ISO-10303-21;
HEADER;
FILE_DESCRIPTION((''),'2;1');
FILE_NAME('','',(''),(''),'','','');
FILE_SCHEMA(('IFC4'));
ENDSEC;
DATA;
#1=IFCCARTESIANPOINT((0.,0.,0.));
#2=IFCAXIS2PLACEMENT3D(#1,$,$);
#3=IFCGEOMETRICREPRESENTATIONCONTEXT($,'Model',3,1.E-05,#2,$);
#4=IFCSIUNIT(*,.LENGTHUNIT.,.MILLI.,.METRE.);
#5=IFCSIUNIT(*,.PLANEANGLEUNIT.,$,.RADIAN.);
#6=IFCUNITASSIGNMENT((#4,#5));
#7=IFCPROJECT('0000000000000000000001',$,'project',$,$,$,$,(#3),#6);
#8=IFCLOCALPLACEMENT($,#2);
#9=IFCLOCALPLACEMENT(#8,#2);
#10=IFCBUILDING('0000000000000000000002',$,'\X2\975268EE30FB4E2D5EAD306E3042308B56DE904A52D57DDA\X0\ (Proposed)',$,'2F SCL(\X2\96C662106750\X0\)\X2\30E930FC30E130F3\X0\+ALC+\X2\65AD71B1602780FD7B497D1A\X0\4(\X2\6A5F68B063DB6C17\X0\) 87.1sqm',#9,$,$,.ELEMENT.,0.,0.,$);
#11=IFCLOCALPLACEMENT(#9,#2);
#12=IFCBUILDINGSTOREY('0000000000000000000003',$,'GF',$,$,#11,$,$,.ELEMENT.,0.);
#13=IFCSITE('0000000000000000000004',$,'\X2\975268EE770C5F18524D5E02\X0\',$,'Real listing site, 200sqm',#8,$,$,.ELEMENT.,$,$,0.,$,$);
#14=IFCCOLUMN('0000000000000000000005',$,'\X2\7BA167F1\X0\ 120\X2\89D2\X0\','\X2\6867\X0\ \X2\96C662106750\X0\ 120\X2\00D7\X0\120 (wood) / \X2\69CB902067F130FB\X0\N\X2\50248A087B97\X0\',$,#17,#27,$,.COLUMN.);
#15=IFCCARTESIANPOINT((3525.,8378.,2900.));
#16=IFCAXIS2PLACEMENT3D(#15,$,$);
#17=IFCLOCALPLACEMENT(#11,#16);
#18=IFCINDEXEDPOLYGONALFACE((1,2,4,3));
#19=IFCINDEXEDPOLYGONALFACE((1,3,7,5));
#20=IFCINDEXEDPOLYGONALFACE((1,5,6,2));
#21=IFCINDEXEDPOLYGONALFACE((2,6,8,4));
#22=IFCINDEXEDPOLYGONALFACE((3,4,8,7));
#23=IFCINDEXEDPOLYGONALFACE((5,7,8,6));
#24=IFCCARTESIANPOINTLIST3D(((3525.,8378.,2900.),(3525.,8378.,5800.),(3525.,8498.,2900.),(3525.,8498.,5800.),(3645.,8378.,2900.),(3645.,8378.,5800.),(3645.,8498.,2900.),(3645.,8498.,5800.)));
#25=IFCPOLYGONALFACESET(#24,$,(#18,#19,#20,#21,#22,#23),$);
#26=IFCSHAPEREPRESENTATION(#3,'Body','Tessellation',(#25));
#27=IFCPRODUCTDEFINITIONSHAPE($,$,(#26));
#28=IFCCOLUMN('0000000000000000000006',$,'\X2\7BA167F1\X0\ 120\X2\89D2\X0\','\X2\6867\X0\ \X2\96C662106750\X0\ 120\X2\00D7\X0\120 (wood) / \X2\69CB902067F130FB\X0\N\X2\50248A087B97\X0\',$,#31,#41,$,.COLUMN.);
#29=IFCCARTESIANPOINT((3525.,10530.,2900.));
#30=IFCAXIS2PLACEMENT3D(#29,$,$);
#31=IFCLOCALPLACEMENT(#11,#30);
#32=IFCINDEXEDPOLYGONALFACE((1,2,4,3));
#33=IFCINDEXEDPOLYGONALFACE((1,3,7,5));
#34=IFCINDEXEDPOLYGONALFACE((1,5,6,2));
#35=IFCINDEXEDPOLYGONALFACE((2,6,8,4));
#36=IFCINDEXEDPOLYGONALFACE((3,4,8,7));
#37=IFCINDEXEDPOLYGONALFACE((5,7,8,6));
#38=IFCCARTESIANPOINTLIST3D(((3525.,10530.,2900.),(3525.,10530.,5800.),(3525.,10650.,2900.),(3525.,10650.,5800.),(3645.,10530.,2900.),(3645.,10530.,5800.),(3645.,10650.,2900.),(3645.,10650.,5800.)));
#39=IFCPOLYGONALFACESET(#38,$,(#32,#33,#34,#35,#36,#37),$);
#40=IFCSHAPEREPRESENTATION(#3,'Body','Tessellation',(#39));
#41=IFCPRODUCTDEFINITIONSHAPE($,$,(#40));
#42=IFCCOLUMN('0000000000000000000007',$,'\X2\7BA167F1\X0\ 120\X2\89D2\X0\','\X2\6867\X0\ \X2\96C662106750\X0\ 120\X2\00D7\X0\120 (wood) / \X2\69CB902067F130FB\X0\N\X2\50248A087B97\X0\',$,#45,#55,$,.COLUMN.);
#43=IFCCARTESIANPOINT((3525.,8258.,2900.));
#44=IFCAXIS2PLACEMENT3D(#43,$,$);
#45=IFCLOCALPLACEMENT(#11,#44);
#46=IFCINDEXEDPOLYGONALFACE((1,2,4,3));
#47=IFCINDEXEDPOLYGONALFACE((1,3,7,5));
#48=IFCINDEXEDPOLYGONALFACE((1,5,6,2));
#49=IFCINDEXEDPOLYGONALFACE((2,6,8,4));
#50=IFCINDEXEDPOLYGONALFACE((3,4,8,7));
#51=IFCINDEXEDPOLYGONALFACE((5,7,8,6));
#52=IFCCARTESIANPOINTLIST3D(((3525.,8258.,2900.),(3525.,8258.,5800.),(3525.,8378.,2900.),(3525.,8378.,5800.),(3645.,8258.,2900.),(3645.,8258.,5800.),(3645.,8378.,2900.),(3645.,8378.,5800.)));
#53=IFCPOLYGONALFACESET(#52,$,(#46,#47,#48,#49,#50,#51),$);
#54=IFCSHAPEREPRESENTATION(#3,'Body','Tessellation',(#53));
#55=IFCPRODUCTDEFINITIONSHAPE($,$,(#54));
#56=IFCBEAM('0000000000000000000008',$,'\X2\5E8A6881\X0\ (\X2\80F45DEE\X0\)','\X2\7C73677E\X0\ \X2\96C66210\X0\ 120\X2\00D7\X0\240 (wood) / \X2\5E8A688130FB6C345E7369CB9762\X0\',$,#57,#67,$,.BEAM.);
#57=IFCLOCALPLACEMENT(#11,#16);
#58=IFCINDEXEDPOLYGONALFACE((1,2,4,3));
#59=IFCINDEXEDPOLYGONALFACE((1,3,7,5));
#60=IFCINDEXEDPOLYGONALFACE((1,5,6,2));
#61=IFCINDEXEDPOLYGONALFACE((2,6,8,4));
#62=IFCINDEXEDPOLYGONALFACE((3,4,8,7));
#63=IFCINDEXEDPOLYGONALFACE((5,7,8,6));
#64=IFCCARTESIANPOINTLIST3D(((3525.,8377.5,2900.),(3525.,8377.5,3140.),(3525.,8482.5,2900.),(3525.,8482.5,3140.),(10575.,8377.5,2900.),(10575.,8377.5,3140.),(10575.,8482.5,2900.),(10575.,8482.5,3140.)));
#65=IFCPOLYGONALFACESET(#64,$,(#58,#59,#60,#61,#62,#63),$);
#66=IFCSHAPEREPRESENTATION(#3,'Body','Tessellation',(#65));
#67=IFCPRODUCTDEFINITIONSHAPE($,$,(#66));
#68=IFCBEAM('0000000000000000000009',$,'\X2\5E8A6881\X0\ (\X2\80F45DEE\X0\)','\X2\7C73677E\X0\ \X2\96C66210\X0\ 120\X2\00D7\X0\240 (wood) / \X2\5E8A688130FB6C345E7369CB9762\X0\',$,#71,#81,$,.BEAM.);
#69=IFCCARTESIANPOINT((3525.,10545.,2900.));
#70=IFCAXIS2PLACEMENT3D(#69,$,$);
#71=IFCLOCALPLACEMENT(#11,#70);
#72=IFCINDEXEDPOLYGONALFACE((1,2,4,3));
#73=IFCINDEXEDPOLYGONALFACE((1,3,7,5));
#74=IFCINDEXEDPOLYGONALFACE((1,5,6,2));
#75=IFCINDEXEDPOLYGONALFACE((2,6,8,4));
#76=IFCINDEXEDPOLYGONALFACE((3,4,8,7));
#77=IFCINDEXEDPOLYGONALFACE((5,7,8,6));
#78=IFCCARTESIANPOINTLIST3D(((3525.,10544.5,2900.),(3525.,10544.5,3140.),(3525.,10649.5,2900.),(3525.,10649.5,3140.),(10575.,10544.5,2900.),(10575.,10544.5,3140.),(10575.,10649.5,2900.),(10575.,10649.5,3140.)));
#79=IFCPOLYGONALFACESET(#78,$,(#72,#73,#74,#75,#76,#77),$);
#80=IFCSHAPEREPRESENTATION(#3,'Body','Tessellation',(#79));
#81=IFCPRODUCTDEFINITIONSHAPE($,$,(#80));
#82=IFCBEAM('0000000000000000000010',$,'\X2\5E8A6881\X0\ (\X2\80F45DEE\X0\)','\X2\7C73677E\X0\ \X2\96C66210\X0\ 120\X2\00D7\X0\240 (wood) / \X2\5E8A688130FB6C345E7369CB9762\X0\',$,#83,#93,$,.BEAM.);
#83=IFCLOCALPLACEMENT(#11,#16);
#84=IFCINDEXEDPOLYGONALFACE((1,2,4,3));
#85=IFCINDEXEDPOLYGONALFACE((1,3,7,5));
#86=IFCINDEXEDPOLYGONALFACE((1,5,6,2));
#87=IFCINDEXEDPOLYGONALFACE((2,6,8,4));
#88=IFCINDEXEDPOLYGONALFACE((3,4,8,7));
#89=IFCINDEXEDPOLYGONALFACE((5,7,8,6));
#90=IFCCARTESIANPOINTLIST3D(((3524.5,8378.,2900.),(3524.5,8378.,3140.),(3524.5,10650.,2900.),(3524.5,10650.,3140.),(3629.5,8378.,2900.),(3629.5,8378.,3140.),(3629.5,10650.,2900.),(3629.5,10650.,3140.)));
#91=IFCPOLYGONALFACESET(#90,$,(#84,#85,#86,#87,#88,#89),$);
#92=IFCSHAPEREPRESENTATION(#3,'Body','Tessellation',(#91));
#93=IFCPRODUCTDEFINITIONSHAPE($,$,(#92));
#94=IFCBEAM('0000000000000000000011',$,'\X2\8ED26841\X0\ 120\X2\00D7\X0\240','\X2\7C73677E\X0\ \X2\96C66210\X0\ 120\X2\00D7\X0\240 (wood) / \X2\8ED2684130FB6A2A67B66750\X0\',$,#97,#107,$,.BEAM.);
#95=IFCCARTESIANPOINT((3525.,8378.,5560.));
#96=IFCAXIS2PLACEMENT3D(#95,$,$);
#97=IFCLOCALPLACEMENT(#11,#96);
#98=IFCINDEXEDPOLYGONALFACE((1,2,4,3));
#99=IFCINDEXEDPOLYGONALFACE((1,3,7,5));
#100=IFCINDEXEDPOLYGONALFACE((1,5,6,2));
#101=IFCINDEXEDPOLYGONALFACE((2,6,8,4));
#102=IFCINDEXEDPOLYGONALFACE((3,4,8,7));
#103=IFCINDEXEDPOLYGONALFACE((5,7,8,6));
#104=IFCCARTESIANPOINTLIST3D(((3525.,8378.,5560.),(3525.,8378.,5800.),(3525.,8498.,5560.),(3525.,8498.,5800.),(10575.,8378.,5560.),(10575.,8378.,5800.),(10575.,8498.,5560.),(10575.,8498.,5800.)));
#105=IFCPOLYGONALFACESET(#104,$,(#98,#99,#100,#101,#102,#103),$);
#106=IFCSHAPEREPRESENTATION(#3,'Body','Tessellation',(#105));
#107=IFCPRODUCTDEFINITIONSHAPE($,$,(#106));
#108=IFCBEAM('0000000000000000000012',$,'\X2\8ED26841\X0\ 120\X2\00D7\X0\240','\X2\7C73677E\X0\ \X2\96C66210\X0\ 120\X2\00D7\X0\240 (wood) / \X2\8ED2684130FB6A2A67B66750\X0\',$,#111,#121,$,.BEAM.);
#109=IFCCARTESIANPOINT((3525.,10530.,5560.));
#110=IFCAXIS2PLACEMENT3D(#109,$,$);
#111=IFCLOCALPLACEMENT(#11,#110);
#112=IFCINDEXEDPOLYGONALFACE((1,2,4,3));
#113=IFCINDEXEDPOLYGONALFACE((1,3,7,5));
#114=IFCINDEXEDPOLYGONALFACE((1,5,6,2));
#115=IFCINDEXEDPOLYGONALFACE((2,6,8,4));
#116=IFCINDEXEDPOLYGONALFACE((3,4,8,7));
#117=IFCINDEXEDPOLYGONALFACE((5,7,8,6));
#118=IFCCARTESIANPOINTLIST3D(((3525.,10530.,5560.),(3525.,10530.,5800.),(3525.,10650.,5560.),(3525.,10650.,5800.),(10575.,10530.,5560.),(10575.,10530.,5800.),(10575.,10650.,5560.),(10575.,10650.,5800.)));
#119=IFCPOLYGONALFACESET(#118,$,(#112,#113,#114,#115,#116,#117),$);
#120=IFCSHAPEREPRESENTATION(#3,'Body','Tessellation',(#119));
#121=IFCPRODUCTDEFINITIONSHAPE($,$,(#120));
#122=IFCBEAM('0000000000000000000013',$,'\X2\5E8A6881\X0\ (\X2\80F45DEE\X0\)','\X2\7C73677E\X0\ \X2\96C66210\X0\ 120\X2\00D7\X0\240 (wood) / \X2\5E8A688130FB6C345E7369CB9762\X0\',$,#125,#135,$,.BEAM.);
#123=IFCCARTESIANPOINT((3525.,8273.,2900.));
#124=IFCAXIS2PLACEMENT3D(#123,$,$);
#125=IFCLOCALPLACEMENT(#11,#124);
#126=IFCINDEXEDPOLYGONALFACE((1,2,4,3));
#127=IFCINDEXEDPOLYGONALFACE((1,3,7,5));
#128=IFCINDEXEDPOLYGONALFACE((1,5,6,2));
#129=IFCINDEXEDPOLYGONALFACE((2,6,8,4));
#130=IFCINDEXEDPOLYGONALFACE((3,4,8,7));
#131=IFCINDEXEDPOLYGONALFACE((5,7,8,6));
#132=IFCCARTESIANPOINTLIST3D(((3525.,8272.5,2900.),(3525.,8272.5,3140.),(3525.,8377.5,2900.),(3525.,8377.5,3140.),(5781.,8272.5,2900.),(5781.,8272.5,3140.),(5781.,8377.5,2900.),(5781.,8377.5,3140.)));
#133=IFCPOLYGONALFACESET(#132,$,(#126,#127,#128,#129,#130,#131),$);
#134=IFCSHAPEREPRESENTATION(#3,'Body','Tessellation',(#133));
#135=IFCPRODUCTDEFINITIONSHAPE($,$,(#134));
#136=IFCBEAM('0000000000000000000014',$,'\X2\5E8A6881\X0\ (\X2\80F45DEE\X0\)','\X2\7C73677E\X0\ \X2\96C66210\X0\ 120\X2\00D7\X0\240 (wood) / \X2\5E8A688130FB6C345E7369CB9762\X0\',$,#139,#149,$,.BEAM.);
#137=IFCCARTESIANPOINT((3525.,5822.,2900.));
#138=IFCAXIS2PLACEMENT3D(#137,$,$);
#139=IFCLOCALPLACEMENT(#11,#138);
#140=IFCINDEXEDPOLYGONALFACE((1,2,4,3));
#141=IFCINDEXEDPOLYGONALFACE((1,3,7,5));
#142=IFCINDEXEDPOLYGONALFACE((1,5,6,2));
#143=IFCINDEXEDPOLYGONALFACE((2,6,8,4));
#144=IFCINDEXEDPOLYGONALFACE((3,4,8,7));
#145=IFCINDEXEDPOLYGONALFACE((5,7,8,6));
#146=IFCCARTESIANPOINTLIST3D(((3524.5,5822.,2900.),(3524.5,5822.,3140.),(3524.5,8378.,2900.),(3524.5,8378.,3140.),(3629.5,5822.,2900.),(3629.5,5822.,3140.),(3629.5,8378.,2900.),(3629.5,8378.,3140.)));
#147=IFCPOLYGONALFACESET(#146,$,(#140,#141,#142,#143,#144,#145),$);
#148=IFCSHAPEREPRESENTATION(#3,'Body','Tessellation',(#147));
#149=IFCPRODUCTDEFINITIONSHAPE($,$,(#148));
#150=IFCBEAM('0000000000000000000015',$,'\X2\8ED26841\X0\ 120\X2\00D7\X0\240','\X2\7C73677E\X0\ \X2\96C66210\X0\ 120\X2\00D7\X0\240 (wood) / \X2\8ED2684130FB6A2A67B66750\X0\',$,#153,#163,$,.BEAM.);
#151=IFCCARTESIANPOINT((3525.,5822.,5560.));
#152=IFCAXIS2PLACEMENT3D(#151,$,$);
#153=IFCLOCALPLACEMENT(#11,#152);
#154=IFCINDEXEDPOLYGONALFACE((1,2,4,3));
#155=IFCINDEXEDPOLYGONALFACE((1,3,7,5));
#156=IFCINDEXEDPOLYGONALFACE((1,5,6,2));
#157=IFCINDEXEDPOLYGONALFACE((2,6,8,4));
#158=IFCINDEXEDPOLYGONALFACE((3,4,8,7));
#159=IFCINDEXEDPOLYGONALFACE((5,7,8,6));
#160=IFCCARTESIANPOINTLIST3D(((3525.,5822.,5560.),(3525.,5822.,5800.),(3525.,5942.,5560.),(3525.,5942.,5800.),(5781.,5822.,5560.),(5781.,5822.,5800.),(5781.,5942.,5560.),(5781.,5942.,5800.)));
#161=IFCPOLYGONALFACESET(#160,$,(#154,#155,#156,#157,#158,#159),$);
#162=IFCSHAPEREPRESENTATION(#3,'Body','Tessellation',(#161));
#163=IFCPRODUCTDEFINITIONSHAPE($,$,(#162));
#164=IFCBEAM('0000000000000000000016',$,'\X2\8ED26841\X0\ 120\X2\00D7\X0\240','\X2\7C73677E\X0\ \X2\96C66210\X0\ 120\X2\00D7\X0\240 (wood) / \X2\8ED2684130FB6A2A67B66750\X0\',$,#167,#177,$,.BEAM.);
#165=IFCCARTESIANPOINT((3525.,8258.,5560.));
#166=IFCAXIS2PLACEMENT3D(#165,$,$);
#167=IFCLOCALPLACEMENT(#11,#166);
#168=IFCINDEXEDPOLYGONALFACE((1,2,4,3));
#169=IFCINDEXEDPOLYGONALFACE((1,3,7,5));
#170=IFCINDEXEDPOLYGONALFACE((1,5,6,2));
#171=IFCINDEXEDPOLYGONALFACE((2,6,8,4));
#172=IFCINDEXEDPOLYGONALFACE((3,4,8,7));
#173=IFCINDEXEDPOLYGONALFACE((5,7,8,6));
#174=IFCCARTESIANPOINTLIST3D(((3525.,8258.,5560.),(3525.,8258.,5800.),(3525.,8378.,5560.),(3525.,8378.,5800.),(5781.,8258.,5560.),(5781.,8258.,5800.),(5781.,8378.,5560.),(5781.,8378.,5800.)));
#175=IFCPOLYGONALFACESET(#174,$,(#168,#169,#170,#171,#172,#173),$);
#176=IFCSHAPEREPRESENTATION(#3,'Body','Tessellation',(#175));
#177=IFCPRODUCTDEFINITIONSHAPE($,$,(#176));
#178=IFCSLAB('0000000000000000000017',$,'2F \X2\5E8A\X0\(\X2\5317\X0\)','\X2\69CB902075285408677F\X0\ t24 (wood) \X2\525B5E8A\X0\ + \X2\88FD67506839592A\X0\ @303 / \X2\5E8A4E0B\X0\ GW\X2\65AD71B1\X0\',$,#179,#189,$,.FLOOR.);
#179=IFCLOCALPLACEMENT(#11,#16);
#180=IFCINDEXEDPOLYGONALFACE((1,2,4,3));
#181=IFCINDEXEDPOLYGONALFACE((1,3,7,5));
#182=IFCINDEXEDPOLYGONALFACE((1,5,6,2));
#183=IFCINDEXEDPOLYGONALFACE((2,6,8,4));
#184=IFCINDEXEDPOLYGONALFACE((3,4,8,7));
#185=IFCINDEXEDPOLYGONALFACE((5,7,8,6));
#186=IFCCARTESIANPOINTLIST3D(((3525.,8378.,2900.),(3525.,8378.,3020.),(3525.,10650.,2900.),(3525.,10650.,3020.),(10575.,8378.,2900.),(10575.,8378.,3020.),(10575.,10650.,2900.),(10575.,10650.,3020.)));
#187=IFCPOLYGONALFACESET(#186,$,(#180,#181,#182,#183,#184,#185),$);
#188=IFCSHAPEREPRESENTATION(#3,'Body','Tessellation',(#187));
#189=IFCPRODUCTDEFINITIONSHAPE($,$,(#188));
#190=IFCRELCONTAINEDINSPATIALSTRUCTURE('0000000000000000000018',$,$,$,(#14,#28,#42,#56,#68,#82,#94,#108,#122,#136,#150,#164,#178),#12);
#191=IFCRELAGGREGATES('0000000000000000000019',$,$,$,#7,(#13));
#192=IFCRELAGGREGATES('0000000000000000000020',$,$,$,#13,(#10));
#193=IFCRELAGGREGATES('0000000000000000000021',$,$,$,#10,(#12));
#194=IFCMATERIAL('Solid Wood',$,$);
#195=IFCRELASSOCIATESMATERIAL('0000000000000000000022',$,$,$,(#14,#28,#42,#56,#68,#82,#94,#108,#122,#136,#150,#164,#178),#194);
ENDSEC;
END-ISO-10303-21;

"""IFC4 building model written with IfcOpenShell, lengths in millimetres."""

from ifc_helpers import new_model, si_unit, frame, frame_2d, origin, place, context, project, spatial, rectangle, extrude, material, element, save


model = new_model("IFC4")

# Units and contexts
model_context = context("Model", 3, precision=1e-05, world=origin())
ifc_project = project(units=[si_unit("LENGTHUNIT", "METRE", prefix="MILLI"), si_unit("PLANEANGLEUNIT", "RADIAN")], contexts=[model_context])

# Site, building, storey
site_placement = place(None, origin())
site = spatial("IfcSite", under=ifc_project, at=site_placement, Name="青森県弘前市", ObjectType="Real listing site, 200sqm", CompositionType="ELEMENT", RefElevation=0.0)
building_placement = place(site_placement, origin())
building = spatial("IfcBuilding", under=site, at=building_placement, Name="青森・中庭のある回遊動線 (Proposed)", ObjectType="2F SCL(集成材)ラーメン+ALC+断熱性能等級4(機械換気) 87.1sqm", CompositionType="ELEMENT", ElevationOfRefHeight=0.0, ElevationOfTerrain=0.0)
storey_placement = place(building_placement, origin())
storey = spatial("IfcBuildingStorey", under=building, at=storey_placement, Name="GF", CompositionType="ELEMENT", Elevation=0.0)

# Columns
ifc_material_1 = material(Name="Solid Wood")
column_1_placement = place(storey_placement, frame((3525.0, 8378.0, 2900.0)))
element("IfcColumn", 1, at=column_1_placement, inside=storey, material=ifc_material_1, Name="管柱 120角", Description="桧 集成材 120×120 (wood) / 構造柱・N値計算", PredefinedType="COLUMN", context=model_context, shape_type="SweptSolid", body=[
    extrude(rectangle(XDim=120.0, YDim=120.0, at=frame_2d((60.0, 60.0))), frame((3525.0, 8378.0, 2900.0)), (0.0, 0.0, 1.0), 2900.0),
])
column_2_placement = place(storey_placement, frame((3525.0, 10530.0, 2900.0)))
element("IfcColumn", 2, at=column_2_placement, inside=storey, material=ifc_material_1, Name="管柱 120角", Description="桧 集成材 120×120 (wood) / 構造柱・N値計算", PredefinedType="COLUMN", context=model_context, shape_type="SweptSolid", body=[
    extrude(rectangle(XDim=120.0, YDim=120.0, at=frame_2d((60.0, 60.0))), frame((3525.0, 10530.0, 2900.0)), (0.0, 0.0, 1.0), 2900.0),
])
column_3_placement = place(storey_placement, frame((3525.0, 8258.0, 2900.0)))
element("IfcColumn", 3, at=column_3_placement, inside=storey, material=ifc_material_1, Name="管柱 120角", Description="桧 集成材 120×120 (wood) / 構造柱・N値計算", PredefinedType="COLUMN", context=model_context, shape_type="SweptSolid", body=[
    extrude(rectangle(XDim=120.0, YDim=120.0, at=frame_2d((60.0, 60.0))), frame((3525.0, 8258.0, 2900.0)), (0.0, 0.0, 1.0), 2900.0),
])

# Beams
beam_1_placement = place(storey_placement, frame((3525.0, 8378.0, 2900.0)))
element("IfcBeam", 4, at=beam_1_placement, inside=storey, material=ifc_material_1, Name="床梁 (胴差)", Description="米松 集成 120×240 (wood) / 床梁・水平構面", PredefinedType="BEAM", context=model_context, shape_type="SweptSolid", body=[
    extrude(rectangle(XDim=7050.0, YDim=105.0, at=frame_2d((3525.0, 52.0))), frame((3525.0, 8378.0, 2900.0)), (0.0, 0.0, 1.0), 240.0),
])
beam_2_placement = place(storey_placement, frame((3525.0, 10545.0, 2900.0)))
element("IfcBeam", 5, at=beam_2_placement, inside=storey, material=ifc_material_1, Name="床梁 (胴差)", Description="米松 集成 120×240 (wood) / 床梁・水平構面", PredefinedType="BEAM", context=model_context, shape_type="SweptSolid", body=[
    extrude(rectangle(XDim=7050.0, YDim=105.0, at=frame_2d((3525.0, 52.0))), frame((3525.0, 10545.0, 2900.0)), (0.0, 0.0, 1.0), 240.0),
])
beam_3_placement = place(storey_placement, frame((3525.0, 8378.0, 2900.0)))
element("IfcBeam", 6, at=beam_3_placement, inside=storey, material=ifc_material_1, Name="床梁 (胴差)", Description="米松 集成 120×240 (wood) / 床梁・水平構面", PredefinedType="BEAM", context=model_context, shape_type="SweptSolid", body=[
    extrude(rectangle(XDim=105.0, YDim=2272.0, at=frame_2d((52.0, 1136.0))), frame((3525.0, 8378.0, 2900.0)), (0.0, 0.0, 1.0), 240.0),
])
beam_4_placement = place(storey_placement, frame((3525.0, 8378.0, 5560.0)))
element("IfcBeam", 7, at=beam_4_placement, inside=storey, material=ifc_material_1, Name="軒桁 120×240", Description="米松 集成 120×240 (wood) / 軒桁・横架材", PredefinedType="BEAM", context=model_context, shape_type="SweptSolid", body=[
    extrude(rectangle(XDim=7050.0, YDim=120.0, at=frame_2d((3525.0, 60.0))), frame((3525.0, 8378.0, 5560.0)), (0.0, 0.0, 1.0), 240.0),
])
beam_5_placement = place(storey_placement, frame((3525.0, 10530.0, 5560.0)))
element("IfcBeam", 8, at=beam_5_placement, inside=storey, material=ifc_material_1, Name="軒桁 120×240", Description="米松 集成 120×240 (wood) / 軒桁・横架材", PredefinedType="BEAM", context=model_context, shape_type="SweptSolid", body=[
    extrude(rectangle(XDim=7050.0, YDim=120.0, at=frame_2d((3525.0, 60.0))), frame((3525.0, 10530.0, 5560.0)), (0.0, 0.0, 1.0), 240.0),
])
beam_6_placement = place(storey_placement, frame((3525.0, 8273.0, 2900.0)))
element("IfcBeam", 9, at=beam_6_placement, inside=storey, material=ifc_material_1, Name="床梁 (胴差)", Description="米松 集成 120×240 (wood) / 床梁・水平構面", PredefinedType="BEAM", context=model_context, shape_type="SweptSolid", body=[
    extrude(rectangle(XDim=2256.0, YDim=105.0, at=frame_2d((1128.0, 52.0))), frame((3525.0, 8273.0, 2900.0)), (0.0, 0.0, 1.0), 240.0),
])
beam_7_placement = place(storey_placement, frame((3525.0, 5822.0, 2900.0)))
element("IfcBeam", 10, at=beam_7_placement, inside=storey, material=ifc_material_1, Name="床梁 (胴差)", Description="米松 集成 120×240 (wood) / 床梁・水平構面", PredefinedType="BEAM", context=model_context, shape_type="SweptSolid", body=[
    extrude(rectangle(XDim=105.0, YDim=2556.0, at=frame_2d((52.0, 1278.0))), frame((3525.0, 5822.0, 2900.0)), (0.0, 0.0, 1.0), 240.0),
])
beam_8_placement = place(storey_placement, frame((3525.0, 5822.0, 5560.0)))
element("IfcBeam", 11, at=beam_8_placement, inside=storey, material=ifc_material_1, Name="軒桁 120×240", Description="米松 集成 120×240 (wood) / 軒桁・横架材", PredefinedType="BEAM", context=model_context, shape_type="SweptSolid", body=[
    extrude(rectangle(XDim=2256.0, YDim=120.0, at=frame_2d((1128.0, 60.0))), frame((3525.0, 5822.0, 5560.0)), (0.0, 0.0, 1.0), 240.0),
])
beam_9_placement = place(storey_placement, frame((3525.0, 8258.0, 5560.0)))
element("IfcBeam", 12, at=beam_9_placement, inside=storey, material=ifc_material_1, Name="軒桁 120×240", Description="米松 集成 120×240 (wood) / 軒桁・横架材", PredefinedType="BEAM", context=model_context, shape_type="SweptSolid", body=[
    extrude(rectangle(XDim=2256.0, YDim=120.0, at=frame_2d((1128.0, 60.0))), frame((3525.0, 8258.0, 5560.0)), (0.0, 0.0, 1.0), 240.0),
])

# Slab
slab_placement = place(storey_placement, frame((3525.0, 8378.0, 2900.0)))
element("IfcSlab", 13, at=slab_placement, inside=storey, material=ifc_material_1, Name="2F 床(北)", Description="構造用合板 t24 (wood) 剛床 + 製材根太 @303 / 床下 GW断熱", PredefinedType="FLOOR", context=model_context, shape_type="SweptSolid", body=[
    extrude(rectangle(XDim=7050.0, YDim=2272.0, at=frame_2d((3525.0, 1136.0))), frame((3525.0, 8378.0, 2900.0)), (0.0, 0.0, 1.0), 120.0),
])

save(model, "model.ifc")
